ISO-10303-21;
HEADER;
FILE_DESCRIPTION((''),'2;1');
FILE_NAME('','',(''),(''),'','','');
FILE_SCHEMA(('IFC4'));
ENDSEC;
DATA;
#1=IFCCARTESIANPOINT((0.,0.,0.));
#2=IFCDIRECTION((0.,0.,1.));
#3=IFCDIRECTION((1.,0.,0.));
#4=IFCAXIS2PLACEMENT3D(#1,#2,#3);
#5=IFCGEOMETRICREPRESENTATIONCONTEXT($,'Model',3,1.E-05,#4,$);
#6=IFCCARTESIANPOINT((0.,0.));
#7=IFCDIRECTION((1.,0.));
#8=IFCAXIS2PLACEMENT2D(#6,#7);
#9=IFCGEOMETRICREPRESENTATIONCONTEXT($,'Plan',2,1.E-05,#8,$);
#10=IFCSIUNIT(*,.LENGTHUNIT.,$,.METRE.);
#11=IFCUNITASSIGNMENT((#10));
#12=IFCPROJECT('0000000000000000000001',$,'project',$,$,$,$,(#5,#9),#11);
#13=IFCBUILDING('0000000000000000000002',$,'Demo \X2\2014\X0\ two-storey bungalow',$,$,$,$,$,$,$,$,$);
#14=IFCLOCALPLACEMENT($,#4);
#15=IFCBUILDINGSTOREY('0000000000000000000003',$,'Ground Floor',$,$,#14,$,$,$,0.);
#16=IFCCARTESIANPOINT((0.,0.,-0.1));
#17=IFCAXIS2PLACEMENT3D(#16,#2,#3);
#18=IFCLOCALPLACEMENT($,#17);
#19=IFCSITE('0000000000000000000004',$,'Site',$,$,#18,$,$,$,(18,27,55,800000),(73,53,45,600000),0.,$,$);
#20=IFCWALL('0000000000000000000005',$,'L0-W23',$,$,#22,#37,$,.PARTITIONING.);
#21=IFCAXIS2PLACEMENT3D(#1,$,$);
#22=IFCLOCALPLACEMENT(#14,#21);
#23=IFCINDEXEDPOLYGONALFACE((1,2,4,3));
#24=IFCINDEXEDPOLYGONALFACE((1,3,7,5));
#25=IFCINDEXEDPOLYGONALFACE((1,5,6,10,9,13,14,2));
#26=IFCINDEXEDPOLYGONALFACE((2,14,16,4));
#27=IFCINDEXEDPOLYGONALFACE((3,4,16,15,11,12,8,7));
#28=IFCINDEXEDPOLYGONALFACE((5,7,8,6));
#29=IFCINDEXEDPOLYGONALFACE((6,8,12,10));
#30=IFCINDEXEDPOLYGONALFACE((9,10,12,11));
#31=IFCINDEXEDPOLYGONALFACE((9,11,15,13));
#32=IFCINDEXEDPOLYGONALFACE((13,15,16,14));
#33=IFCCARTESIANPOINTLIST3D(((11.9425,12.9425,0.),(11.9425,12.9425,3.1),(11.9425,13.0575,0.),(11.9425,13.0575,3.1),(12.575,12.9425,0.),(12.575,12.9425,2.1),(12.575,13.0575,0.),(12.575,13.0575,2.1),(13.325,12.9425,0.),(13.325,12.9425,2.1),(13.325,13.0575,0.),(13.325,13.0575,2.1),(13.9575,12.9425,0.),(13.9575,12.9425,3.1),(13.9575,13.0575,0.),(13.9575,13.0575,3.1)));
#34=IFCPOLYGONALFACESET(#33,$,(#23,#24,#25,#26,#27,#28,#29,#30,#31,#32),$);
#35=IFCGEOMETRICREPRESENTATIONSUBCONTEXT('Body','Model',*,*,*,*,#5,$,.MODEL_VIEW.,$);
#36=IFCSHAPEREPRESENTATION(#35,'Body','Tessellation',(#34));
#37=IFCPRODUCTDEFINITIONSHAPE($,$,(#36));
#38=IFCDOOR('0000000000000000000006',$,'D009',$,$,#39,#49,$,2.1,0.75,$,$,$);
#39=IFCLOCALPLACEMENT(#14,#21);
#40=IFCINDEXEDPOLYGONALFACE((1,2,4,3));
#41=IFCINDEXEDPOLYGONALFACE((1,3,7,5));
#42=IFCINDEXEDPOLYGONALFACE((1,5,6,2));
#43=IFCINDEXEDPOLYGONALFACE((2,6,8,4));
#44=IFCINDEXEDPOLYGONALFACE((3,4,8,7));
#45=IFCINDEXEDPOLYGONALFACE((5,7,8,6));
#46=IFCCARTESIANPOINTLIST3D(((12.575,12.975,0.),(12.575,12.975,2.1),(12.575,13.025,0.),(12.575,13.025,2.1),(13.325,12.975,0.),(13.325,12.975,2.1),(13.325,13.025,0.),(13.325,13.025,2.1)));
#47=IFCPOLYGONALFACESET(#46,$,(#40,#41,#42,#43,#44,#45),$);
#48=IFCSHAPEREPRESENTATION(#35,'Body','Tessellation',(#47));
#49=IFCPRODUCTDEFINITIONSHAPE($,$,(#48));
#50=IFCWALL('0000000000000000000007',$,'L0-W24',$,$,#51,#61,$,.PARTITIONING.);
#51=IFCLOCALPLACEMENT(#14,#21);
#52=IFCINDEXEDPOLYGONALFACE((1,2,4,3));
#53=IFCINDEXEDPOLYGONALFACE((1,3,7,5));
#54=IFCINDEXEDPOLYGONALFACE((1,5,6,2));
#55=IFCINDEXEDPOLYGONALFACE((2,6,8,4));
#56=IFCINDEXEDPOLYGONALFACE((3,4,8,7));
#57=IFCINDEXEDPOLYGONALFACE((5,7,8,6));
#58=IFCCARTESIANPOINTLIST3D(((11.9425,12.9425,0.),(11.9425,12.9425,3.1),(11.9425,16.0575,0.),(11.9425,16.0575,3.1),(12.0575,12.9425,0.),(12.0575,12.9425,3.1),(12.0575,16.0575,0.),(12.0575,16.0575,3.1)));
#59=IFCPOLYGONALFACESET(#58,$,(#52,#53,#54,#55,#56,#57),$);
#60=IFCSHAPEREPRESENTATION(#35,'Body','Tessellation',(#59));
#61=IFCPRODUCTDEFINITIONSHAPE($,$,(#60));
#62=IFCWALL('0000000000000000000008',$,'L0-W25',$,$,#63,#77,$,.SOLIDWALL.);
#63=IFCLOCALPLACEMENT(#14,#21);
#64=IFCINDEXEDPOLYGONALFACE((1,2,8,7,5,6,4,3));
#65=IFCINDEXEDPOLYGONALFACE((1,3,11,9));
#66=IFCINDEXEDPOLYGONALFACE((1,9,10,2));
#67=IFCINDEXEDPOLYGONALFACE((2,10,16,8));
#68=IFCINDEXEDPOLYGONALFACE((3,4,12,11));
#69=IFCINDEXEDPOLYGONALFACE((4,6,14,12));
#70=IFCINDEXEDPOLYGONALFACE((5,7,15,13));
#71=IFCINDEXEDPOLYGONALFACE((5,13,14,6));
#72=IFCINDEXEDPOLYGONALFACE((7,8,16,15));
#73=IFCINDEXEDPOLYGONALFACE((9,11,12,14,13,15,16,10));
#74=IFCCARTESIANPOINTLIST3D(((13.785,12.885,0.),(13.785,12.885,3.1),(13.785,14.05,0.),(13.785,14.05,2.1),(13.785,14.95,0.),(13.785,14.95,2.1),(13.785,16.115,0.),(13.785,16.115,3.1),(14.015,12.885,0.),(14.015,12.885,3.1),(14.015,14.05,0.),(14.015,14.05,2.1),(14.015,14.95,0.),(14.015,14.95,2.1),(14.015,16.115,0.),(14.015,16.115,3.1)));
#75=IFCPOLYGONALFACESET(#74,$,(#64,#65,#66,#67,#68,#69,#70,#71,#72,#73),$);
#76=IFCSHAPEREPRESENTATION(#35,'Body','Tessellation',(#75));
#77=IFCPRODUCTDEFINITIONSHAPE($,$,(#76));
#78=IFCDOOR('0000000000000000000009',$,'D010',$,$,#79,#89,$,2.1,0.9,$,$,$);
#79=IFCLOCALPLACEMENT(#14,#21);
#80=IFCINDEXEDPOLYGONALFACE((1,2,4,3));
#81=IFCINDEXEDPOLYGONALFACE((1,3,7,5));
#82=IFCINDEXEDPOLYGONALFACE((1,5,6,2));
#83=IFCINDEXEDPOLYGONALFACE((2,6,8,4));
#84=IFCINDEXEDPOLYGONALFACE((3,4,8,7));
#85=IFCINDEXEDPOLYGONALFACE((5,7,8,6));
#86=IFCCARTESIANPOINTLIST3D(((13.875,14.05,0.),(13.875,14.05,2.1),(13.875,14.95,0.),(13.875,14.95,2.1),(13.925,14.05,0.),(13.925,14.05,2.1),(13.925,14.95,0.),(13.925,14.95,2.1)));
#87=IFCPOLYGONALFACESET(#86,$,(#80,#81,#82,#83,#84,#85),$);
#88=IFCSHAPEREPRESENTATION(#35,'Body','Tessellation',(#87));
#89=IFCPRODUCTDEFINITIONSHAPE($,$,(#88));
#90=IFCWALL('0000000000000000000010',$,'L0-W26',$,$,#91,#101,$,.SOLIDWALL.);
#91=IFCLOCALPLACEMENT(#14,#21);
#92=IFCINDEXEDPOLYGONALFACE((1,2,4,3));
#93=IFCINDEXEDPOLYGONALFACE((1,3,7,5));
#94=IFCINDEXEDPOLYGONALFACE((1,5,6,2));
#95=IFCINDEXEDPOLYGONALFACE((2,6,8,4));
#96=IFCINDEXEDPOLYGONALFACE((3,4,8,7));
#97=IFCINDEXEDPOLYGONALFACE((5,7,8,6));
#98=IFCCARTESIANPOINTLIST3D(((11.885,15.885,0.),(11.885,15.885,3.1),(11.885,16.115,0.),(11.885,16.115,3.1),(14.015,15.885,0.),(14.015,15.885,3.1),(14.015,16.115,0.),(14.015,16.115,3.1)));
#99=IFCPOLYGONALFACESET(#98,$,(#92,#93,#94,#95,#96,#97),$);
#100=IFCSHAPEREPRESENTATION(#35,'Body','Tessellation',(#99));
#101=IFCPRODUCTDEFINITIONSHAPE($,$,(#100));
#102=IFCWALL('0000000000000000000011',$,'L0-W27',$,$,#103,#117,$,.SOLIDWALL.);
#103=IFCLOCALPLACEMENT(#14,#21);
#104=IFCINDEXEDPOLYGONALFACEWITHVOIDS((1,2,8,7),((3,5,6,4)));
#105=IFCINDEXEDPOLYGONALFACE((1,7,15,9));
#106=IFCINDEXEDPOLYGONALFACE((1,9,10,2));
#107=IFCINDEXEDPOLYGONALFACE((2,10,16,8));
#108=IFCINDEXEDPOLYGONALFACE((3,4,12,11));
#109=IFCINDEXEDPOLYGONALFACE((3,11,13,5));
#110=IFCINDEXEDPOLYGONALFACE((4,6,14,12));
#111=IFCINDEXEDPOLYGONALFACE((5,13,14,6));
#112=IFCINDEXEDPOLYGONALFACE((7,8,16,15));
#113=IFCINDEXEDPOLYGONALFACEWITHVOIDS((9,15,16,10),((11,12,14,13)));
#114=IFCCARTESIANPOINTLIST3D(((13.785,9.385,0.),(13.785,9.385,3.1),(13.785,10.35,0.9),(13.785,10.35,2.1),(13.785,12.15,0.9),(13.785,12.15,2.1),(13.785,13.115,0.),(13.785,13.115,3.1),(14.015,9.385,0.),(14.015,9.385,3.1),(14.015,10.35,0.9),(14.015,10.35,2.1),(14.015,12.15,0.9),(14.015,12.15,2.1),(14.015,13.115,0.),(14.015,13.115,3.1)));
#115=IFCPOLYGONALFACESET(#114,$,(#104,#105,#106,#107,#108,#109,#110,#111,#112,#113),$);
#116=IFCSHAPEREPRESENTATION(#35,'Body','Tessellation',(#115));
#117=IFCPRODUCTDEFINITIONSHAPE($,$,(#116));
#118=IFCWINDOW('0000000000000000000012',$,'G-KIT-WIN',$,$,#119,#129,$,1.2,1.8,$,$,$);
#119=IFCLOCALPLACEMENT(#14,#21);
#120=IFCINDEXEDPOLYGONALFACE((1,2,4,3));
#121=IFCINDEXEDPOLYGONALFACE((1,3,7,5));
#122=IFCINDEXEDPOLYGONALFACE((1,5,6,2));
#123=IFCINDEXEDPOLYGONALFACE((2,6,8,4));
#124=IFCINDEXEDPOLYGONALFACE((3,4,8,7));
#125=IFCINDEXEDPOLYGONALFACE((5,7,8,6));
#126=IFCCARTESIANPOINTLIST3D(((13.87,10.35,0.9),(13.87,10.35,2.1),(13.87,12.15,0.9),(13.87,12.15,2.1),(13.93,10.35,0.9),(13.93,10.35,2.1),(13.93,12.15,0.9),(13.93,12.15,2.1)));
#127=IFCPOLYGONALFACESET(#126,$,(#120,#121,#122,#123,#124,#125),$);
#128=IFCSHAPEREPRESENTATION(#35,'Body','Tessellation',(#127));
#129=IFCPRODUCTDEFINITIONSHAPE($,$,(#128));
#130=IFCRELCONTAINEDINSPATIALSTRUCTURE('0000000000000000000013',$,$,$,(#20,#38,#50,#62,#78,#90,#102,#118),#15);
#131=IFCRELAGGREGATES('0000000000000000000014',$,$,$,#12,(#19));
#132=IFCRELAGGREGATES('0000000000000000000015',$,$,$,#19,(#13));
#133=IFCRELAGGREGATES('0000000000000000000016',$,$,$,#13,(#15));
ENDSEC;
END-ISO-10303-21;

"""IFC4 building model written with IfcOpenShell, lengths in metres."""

from ifc_helpers import new_model, si_unit, frame, origin_with_axes, origin_2d_with_axis, place, context, subcontext, project, spatial, line, indexed_curve, outline, extrude, element, fill, save


model = new_model("IFC4")

# Units and contexts
model_context = context("Model", 3, precision=1e-05, world=origin_with_axes())
plan_context = context("Plan", 2, precision=1e-05, world=origin_2d_with_axis())
body_context = subcontext(model_context, "Body", "Model", "MODEL_VIEW")
ifc_project = project(units=[si_unit("LENGTHUNIT", "METRE")], contexts=[model_context, plan_context])

# Site, building, storey
site_placement = place(None, frame((0.0, 0.0, -0.1), z_axis=(0.0, 0.0, 1.0), x_axis=(1.0, 0.0, 0.0)))
site = spatial("IfcSite", under=ifc_project, at=site_placement, Name="Site", RefLatitude=(18, 27, 55, 800000), RefLongitude=(73, 53, 45, 600000), RefElevation=0.0)
building = spatial("IfcBuilding", under=site, Name="Demo — two-storey bungalow")
storey_placement = place(None, origin_with_axes())
storey = spatial("IfcBuildingStorey", under=building, at=storey_placement, Name="Ground Floor", Elevation=0.0)

# Wall, opening, door
wall_1_placement = place(storey_placement, origin_with_axes())
wall_1 = element("IfcWall", 1, at=wall_1_placement, inside=storey, Name="L0-W23", PredefinedType="PARTITIONING", context=body_context, shape_type="SweptSolid", body=[
    extrude(outline(indexed_curve([(13.9575, 12.9425), (11.9425, 12.9425), (11.9425, 13.0575), (13.9575, 13.0575)], segments=[line(1, 2, 3, 4, 1)])), origin_with_axes(), (0.0, 0.0, 1.0), 3.1),
])
opening_1_placement = place(wall_1_placement, origin_with_axes())
opening_1 = element("IfcOpeningElement", 2, at=opening_1_placement, cuts=wall_1, context=body_context, shape_type="SweptSolid", body=[
    extrude(outline(indexed_curve([(13.325, 12.8925), (12.575, 12.8925), (12.575, 13.1075), (13.325, 13.1075)], segments=[line(1, 2, 3, 4, 1)])), origin_with_axes(), (0.0, 0.0, 1.0), 2.1),
])
door_1_placement = place(storey_placement, origin_with_axes())
door_1 = element("IfcDoor", 3, at=door_1_placement, inside=storey, Name="D009", OverallHeight=2.1, OverallWidth=0.75, context=body_context, shape_type="SweptSolid", body=[
    extrude(outline(indexed_curve([(13.325, 12.975), (12.575, 12.975), (12.575, 13.025), (13.325, 13.025)], segments=[line(1, 2, 3, 4, 1)])), origin_with_axes(), (0.0, 0.0, 1.0), 2.1),
])
fill(opening_1, door_1)

# Wall
wall_2_placement = place(storey_placement, origin_with_axes())
element("IfcWall", 4, at=wall_2_placement, inside=storey, Name="L0-W24", PredefinedType="PARTITIONING", context=body_context, shape_type="SweptSolid", body=[
    extrude(outline(indexed_curve([(11.9425, 12.9425), (11.9425, 16.0575), (12.0575, 16.0575), (12.0575, 12.9425)], segments=[line(1, 2, 3, 4, 1)])), origin_with_axes(), (0.0, 0.0, 1.0), 3.1),
])

# Wall, opening, door
wall_3_placement = place(storey_placement, origin_with_axes())
wall_3 = element("IfcWall", 5, at=wall_3_placement, inside=storey, Name="L0-W25", PredefinedType="SOLIDWALL", context=body_context, shape_type="SweptSolid", body=[
    extrude(outline(indexed_curve([(13.785, 12.885), (13.785, 16.115), (14.015, 16.115), (14.015, 12.885)], segments=[line(1, 2, 3, 4, 1)])), origin_with_axes(), (0.0, 0.0, 1.0), 3.1),
])
opening_2_placement = place(wall_3_placement, origin_with_axes())
opening_2 = element("IfcOpeningElement", 6, at=opening_2_placement, cuts=wall_3, context=body_context, shape_type="SweptSolid", body=[
    extrude(outline(indexed_curve([(13.735, 14.05), (13.735, 14.95), (14.065, 14.95), (14.065, 14.05)], segments=[line(1, 2, 3, 4, 1)])), origin_with_axes(), (0.0, 0.0, 1.0), 2.1),
])
door_2_placement = place(storey_placement, origin_with_axes())
door_2 = element("IfcDoor", 7, at=door_2_placement, inside=storey, Name="D010", OverallHeight=2.1, OverallWidth=0.9, context=body_context, shape_type="SweptSolid", body=[
    extrude(outline(indexed_curve([(13.875, 14.05), (13.875, 14.95), (13.925, 14.95), (13.925, 14.05)], segments=[line(1, 2, 3, 4, 1)])), origin_with_axes(), (0.0, 0.0, 1.0), 2.1),
])
fill(opening_2, door_2)

# Wall
wall_4_placement = place(storey_placement, origin_with_axes())
element("IfcWall", 8, at=wall_4_placement, inside=storey, Name="L0-W26", PredefinedType="SOLIDWALL", context=body_context, shape_type="SweptSolid", body=[
    extrude(outline(indexed_curve([(14.015, 15.885), (11.885, 15.885), (11.885, 16.115), (14.015, 16.115)], segments=[line(1, 2, 3, 4, 1)])), origin_with_axes(), (0.0, 0.0, 1.0), 3.1),
])

# Wall, opening, window
wall_5_placement = place(storey_placement, origin_with_axes())
wall_5 = element("IfcWall", 9, at=wall_5_placement, inside=storey, Name="L0-W27", PredefinedType="SOLIDWALL", context=body_context, shape_type="SweptSolid", body=[
    extrude(outline(indexed_curve([(13.785, 9.385), (13.785, 13.115), (14.015, 13.115), (14.015, 9.385)], segments=[line(1, 2, 3, 4, 1)])), origin_with_axes(), (0.0, 0.0, 1.0), 3.1),
])
opening_3_placement = place(wall_5_placement, origin_with_axes())
opening_3 = element("IfcOpeningElement", 10, at=opening_3_placement, cuts=wall_5, context=body_context, shape_type="SweptSolid", body=[
    extrude(outline(indexed_curve([(13.735, 10.35), (13.735, 12.15), (14.065, 12.15), (14.065, 10.35)], segments=[line(1, 2, 3, 4, 1)])), frame((0.0, 0.0, 0.9), z_axis=(0.0, 0.0, 1.0), x_axis=(1.0, 0.0, 0.0)), (0.0, 0.0, 1.0), 1.2),
])
window_1_placement = place(storey_placement, origin_with_axes())
window_1 = element("IfcWindow", 11, at=window_1_placement, inside=storey, Name="G-KIT-WIN", OverallHeight=1.2, OverallWidth=1.8, context=body_context, shape_type="SweptSolid", body=[
    extrude(outline(indexed_curve([(13.87, 10.35), (13.87, 12.15), (13.93, 12.15), (13.93, 10.35)], segments=[line(1, 2, 3, 4, 1)])), frame((0.0, 0.0, 0.9), z_axis=(0.0, 0.0, 1.0), x_axis=(1.0, 0.0, 0.0)), (0.0, 0.0, 1.0), 1.2),
])
fill(opening_3, window_1)

save(model, "model.ifc")
